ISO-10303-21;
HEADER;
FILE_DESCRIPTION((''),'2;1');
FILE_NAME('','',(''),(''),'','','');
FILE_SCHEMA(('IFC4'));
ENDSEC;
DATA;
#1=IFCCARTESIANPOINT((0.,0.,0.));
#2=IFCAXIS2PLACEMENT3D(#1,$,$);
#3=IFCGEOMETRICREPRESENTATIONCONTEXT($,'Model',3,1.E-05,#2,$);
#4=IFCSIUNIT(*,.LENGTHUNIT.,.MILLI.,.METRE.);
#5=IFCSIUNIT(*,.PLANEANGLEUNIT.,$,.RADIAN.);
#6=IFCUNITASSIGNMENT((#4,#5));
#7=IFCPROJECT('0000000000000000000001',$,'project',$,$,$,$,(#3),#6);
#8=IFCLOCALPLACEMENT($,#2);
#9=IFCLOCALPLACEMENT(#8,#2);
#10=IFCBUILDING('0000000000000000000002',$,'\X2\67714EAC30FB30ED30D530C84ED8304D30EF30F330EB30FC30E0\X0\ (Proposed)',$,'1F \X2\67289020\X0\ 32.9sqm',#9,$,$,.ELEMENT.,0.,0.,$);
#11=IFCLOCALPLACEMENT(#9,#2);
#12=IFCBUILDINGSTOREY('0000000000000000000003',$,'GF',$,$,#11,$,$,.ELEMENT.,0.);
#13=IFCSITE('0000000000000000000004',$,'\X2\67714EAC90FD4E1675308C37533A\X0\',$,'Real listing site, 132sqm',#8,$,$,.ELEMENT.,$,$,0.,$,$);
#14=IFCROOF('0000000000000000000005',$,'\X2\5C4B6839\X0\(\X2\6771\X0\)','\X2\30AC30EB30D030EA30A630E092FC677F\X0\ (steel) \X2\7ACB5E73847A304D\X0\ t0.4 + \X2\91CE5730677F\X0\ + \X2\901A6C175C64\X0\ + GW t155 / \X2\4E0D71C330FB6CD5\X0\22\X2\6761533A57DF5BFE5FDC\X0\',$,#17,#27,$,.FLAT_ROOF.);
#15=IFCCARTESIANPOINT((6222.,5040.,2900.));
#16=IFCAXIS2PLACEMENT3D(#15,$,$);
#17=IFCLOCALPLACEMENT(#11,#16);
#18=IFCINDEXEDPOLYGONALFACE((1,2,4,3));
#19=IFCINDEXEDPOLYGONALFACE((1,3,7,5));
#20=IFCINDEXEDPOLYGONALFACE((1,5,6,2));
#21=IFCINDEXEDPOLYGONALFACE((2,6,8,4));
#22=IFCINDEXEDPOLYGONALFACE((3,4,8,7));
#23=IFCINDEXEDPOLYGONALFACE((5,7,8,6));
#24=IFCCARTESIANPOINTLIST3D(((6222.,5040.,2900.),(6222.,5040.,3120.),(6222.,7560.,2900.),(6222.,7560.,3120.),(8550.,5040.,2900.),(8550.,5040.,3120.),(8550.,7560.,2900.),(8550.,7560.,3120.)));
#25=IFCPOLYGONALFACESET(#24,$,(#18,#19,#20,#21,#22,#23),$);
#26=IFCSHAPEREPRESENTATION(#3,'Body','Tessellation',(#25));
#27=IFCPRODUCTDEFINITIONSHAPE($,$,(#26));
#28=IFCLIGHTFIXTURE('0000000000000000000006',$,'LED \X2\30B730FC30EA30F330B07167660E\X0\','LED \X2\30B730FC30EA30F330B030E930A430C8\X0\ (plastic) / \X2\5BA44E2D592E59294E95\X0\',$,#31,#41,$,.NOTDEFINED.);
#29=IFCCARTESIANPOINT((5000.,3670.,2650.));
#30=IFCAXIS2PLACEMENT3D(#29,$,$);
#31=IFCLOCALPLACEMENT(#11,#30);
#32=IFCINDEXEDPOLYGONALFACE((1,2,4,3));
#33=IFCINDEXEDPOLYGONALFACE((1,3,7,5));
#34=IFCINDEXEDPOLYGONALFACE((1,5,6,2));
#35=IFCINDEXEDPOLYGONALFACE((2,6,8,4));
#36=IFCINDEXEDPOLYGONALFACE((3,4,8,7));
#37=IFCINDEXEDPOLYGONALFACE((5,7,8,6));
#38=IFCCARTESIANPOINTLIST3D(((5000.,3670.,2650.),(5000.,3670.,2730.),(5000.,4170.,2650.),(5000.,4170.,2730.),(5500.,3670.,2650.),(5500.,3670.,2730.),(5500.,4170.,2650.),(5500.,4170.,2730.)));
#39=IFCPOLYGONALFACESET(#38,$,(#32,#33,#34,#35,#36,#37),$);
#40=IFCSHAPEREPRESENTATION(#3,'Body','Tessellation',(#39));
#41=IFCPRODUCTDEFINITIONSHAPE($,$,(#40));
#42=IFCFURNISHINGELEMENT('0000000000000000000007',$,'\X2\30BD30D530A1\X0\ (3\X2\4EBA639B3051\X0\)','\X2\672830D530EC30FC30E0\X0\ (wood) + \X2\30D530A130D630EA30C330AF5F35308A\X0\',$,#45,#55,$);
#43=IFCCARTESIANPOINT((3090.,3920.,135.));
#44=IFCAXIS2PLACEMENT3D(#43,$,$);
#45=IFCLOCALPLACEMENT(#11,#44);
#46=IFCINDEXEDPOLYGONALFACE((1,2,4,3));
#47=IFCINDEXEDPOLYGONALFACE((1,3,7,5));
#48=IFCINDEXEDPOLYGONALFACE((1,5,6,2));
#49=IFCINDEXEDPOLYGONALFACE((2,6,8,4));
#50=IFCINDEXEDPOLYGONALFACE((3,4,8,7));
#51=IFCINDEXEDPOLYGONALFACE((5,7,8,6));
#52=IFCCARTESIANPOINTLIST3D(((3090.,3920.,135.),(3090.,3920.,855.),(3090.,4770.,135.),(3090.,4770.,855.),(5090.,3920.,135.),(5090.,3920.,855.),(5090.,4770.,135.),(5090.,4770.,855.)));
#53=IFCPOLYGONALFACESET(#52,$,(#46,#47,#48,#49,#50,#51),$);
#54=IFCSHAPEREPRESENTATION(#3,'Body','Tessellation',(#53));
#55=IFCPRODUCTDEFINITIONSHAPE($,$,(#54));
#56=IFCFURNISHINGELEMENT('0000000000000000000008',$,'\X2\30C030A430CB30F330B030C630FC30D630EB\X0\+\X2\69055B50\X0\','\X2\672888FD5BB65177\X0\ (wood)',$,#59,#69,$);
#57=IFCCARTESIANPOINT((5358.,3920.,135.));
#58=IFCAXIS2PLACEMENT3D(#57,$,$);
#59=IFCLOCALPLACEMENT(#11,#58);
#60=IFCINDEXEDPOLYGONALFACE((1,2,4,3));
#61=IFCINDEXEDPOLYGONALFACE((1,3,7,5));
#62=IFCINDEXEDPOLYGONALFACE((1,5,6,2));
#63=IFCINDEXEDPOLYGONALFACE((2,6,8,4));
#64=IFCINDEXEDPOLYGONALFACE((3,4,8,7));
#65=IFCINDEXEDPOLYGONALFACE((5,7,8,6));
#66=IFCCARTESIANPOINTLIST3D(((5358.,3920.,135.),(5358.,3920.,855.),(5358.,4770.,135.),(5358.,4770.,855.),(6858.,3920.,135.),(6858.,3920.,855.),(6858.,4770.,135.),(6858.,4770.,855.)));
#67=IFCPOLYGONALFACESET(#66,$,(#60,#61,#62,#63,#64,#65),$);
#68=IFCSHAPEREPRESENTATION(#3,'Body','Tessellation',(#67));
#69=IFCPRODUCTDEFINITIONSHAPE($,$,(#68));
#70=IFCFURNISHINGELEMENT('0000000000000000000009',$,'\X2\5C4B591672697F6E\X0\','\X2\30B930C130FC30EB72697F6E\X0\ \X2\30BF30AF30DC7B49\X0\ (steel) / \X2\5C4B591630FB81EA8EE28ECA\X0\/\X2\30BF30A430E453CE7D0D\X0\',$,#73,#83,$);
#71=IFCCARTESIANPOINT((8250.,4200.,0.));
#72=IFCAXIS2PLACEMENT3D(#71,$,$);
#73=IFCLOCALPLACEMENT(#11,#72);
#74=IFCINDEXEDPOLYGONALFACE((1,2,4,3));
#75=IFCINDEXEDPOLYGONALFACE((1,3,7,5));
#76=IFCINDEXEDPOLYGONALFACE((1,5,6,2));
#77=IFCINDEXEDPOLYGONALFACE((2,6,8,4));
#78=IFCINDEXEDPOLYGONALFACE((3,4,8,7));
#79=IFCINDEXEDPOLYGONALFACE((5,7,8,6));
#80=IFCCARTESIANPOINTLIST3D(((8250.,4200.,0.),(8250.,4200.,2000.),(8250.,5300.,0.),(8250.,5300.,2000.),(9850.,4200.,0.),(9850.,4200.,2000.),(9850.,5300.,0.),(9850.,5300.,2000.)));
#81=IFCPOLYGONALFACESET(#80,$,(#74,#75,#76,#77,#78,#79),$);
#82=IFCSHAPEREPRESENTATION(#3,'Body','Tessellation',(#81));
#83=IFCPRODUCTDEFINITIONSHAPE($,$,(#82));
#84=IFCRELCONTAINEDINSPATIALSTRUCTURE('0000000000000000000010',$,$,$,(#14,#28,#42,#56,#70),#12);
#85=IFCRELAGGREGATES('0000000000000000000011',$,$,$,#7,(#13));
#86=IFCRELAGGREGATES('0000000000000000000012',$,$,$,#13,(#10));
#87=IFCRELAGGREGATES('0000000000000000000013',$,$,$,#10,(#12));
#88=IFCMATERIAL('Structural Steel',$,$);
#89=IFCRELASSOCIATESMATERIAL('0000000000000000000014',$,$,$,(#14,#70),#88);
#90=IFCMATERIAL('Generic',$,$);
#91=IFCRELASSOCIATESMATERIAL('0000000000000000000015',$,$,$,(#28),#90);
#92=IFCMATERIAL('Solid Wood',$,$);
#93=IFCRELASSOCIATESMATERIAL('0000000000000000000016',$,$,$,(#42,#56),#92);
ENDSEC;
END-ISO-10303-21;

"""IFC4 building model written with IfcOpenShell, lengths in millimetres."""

from ifc_helpers import new_model, si_unit, frame, frame_2d, origin, place, context, project, spatial, rectangle, extrude, material, element, save


model = new_model("IFC4")

# Units and contexts
model_context = context("Model", 3, precision=1e-05, world=origin())
ifc_project = project(units=[si_unit("LENGTHUNIT", "METRE", prefix="MILLI"), si_unit("PLANEANGLEUNIT", "RADIAN")], contexts=[model_context])

# Site, building, storey
site_placement = place(None, origin())
site = spatial("IfcSite", under=ifc_project, at=site_placement, Name="東京都世田谷区", ObjectType="Real listing site, 132sqm", CompositionType="ELEMENT", RefElevation=0.0)
building_placement = place(site_placement, origin())
building = spatial("IfcBuilding", under=site, at=building_placement, Name="東京・ロフト付きワンルーム (Proposed)", ObjectType="1F 木造 32.9sqm", CompositionType="ELEMENT", ElevationOfRefHeight=0.0, ElevationOfTerrain=0.0)
storey_placement = place(building_placement, origin())
storey = spatial("IfcBuildingStorey", under=building, at=storey_placement, Name="GF", CompositionType="ELEMENT", Elevation=0.0)

# Shared definitions
ifc_material_1 = material(Name="Solid Wood")

# Roof
ifc_material_2 = material(Name="Structural Steel")
roof_1_placement = place(storey_placement, frame((6222.0, 5040.0, 2900.0)))
element("IfcRoof", 1, at=roof_1_placement, inside=storey, material=ifc_material_2, Name="屋根(東)", Description="ガルバリウム鋼板 (steel) 立平葺き t0.4 + 野地板 + 通気層 + GW t155 / 不燃・法22条区域対応", PredefinedType="FLAT_ROOF", context=model_context, shape_type="SweptSolid", body=[
    extrude(rectangle(XDim=2328.0, YDim=2520.0, at=frame_2d((1164.0, 1260.0))), frame((6222.0, 5040.0, 2900.0)), (0.0, 0.0, 1.0), 220.0),
])

# Light fixture
ifc_material_3 = material(Name="Generic")
light_fixture_placement = place(storey_placement, frame((5000.0, 3670.0, 2650.0)))
element("IfcLightFixture", 2, at=light_fixture_placement, inside=storey, material=ifc_material_3, Name="LED シーリング照明", Description="LED シーリングライト (plastic) / 室中央天井", PredefinedType="NOTDEFINED", context=model_context, shape_type="SweptSolid", body=[
    extrude(rectangle(XDim=500.0, YDim=500.0, at=frame_2d((250.0, 250.0))), frame((5000.0, 3670.0, 2650.0)), (0.0, 0.0, 1.0), 80.0),
])

# Furnishing elements
furnishing_1_placement = place(storey_placement, frame((3090.0, 3920.0, 135.0)))
element("IfcFurnishingElement", 3, at=furnishing_1_placement, inside=storey, material=ifc_material_1, Name="ソファ (3人掛け)", Description="木フレーム (wood) + ファブリック張り", context=model_context, shape_type="SweptSolid", body=[
    extrude(rectangle(XDim=2000.0, YDim=850.0, at=frame_2d((1000.0, 425.0))), frame((3090.0, 3920.0, 135.0)), (0.0, 0.0, 1.0), 720.0),
])
furnishing_2_placement = place(storey_placement, frame((5358.0, 3920.0, 135.0)))
element("IfcFurnishingElement", 4, at=furnishing_2_placement, inside=storey, material=ifc_material_1, Name="ダイニングテーブル+椅子", Description="木製家具 (wood)", context=model_context, shape_type="SweptSolid", body=[
    extrude(rectangle(XDim=1500.0, YDim=850.0, at=frame_2d((750.0, 425.0))), frame((5358.0, 3920.0, 135.0)), (0.0, 0.0, 1.0), 720.0),
])
furnishing_3_placement = place(storey_placement, frame((8250.0, 4200.0, 0.0)))
element("IfcFurnishingElement", 5, at=furnishing_3_placement, inside=storey, material=ifc_material_2, Name="屋外物置", Description="スチール物置 タクボ等 (steel) / 屋外・自転車/タイヤ収納", context=model_context, shape_type="SweptSolid", body=[
    extrude(rectangle(XDim=1600.0, YDim=1100.0, at=frame_2d((800.0, 550.0))), frame((8250.0, 4200.0, 0.0)), (0.0, 0.0, 1.0), 2000.0),
])

save(model, "model.ifc")
